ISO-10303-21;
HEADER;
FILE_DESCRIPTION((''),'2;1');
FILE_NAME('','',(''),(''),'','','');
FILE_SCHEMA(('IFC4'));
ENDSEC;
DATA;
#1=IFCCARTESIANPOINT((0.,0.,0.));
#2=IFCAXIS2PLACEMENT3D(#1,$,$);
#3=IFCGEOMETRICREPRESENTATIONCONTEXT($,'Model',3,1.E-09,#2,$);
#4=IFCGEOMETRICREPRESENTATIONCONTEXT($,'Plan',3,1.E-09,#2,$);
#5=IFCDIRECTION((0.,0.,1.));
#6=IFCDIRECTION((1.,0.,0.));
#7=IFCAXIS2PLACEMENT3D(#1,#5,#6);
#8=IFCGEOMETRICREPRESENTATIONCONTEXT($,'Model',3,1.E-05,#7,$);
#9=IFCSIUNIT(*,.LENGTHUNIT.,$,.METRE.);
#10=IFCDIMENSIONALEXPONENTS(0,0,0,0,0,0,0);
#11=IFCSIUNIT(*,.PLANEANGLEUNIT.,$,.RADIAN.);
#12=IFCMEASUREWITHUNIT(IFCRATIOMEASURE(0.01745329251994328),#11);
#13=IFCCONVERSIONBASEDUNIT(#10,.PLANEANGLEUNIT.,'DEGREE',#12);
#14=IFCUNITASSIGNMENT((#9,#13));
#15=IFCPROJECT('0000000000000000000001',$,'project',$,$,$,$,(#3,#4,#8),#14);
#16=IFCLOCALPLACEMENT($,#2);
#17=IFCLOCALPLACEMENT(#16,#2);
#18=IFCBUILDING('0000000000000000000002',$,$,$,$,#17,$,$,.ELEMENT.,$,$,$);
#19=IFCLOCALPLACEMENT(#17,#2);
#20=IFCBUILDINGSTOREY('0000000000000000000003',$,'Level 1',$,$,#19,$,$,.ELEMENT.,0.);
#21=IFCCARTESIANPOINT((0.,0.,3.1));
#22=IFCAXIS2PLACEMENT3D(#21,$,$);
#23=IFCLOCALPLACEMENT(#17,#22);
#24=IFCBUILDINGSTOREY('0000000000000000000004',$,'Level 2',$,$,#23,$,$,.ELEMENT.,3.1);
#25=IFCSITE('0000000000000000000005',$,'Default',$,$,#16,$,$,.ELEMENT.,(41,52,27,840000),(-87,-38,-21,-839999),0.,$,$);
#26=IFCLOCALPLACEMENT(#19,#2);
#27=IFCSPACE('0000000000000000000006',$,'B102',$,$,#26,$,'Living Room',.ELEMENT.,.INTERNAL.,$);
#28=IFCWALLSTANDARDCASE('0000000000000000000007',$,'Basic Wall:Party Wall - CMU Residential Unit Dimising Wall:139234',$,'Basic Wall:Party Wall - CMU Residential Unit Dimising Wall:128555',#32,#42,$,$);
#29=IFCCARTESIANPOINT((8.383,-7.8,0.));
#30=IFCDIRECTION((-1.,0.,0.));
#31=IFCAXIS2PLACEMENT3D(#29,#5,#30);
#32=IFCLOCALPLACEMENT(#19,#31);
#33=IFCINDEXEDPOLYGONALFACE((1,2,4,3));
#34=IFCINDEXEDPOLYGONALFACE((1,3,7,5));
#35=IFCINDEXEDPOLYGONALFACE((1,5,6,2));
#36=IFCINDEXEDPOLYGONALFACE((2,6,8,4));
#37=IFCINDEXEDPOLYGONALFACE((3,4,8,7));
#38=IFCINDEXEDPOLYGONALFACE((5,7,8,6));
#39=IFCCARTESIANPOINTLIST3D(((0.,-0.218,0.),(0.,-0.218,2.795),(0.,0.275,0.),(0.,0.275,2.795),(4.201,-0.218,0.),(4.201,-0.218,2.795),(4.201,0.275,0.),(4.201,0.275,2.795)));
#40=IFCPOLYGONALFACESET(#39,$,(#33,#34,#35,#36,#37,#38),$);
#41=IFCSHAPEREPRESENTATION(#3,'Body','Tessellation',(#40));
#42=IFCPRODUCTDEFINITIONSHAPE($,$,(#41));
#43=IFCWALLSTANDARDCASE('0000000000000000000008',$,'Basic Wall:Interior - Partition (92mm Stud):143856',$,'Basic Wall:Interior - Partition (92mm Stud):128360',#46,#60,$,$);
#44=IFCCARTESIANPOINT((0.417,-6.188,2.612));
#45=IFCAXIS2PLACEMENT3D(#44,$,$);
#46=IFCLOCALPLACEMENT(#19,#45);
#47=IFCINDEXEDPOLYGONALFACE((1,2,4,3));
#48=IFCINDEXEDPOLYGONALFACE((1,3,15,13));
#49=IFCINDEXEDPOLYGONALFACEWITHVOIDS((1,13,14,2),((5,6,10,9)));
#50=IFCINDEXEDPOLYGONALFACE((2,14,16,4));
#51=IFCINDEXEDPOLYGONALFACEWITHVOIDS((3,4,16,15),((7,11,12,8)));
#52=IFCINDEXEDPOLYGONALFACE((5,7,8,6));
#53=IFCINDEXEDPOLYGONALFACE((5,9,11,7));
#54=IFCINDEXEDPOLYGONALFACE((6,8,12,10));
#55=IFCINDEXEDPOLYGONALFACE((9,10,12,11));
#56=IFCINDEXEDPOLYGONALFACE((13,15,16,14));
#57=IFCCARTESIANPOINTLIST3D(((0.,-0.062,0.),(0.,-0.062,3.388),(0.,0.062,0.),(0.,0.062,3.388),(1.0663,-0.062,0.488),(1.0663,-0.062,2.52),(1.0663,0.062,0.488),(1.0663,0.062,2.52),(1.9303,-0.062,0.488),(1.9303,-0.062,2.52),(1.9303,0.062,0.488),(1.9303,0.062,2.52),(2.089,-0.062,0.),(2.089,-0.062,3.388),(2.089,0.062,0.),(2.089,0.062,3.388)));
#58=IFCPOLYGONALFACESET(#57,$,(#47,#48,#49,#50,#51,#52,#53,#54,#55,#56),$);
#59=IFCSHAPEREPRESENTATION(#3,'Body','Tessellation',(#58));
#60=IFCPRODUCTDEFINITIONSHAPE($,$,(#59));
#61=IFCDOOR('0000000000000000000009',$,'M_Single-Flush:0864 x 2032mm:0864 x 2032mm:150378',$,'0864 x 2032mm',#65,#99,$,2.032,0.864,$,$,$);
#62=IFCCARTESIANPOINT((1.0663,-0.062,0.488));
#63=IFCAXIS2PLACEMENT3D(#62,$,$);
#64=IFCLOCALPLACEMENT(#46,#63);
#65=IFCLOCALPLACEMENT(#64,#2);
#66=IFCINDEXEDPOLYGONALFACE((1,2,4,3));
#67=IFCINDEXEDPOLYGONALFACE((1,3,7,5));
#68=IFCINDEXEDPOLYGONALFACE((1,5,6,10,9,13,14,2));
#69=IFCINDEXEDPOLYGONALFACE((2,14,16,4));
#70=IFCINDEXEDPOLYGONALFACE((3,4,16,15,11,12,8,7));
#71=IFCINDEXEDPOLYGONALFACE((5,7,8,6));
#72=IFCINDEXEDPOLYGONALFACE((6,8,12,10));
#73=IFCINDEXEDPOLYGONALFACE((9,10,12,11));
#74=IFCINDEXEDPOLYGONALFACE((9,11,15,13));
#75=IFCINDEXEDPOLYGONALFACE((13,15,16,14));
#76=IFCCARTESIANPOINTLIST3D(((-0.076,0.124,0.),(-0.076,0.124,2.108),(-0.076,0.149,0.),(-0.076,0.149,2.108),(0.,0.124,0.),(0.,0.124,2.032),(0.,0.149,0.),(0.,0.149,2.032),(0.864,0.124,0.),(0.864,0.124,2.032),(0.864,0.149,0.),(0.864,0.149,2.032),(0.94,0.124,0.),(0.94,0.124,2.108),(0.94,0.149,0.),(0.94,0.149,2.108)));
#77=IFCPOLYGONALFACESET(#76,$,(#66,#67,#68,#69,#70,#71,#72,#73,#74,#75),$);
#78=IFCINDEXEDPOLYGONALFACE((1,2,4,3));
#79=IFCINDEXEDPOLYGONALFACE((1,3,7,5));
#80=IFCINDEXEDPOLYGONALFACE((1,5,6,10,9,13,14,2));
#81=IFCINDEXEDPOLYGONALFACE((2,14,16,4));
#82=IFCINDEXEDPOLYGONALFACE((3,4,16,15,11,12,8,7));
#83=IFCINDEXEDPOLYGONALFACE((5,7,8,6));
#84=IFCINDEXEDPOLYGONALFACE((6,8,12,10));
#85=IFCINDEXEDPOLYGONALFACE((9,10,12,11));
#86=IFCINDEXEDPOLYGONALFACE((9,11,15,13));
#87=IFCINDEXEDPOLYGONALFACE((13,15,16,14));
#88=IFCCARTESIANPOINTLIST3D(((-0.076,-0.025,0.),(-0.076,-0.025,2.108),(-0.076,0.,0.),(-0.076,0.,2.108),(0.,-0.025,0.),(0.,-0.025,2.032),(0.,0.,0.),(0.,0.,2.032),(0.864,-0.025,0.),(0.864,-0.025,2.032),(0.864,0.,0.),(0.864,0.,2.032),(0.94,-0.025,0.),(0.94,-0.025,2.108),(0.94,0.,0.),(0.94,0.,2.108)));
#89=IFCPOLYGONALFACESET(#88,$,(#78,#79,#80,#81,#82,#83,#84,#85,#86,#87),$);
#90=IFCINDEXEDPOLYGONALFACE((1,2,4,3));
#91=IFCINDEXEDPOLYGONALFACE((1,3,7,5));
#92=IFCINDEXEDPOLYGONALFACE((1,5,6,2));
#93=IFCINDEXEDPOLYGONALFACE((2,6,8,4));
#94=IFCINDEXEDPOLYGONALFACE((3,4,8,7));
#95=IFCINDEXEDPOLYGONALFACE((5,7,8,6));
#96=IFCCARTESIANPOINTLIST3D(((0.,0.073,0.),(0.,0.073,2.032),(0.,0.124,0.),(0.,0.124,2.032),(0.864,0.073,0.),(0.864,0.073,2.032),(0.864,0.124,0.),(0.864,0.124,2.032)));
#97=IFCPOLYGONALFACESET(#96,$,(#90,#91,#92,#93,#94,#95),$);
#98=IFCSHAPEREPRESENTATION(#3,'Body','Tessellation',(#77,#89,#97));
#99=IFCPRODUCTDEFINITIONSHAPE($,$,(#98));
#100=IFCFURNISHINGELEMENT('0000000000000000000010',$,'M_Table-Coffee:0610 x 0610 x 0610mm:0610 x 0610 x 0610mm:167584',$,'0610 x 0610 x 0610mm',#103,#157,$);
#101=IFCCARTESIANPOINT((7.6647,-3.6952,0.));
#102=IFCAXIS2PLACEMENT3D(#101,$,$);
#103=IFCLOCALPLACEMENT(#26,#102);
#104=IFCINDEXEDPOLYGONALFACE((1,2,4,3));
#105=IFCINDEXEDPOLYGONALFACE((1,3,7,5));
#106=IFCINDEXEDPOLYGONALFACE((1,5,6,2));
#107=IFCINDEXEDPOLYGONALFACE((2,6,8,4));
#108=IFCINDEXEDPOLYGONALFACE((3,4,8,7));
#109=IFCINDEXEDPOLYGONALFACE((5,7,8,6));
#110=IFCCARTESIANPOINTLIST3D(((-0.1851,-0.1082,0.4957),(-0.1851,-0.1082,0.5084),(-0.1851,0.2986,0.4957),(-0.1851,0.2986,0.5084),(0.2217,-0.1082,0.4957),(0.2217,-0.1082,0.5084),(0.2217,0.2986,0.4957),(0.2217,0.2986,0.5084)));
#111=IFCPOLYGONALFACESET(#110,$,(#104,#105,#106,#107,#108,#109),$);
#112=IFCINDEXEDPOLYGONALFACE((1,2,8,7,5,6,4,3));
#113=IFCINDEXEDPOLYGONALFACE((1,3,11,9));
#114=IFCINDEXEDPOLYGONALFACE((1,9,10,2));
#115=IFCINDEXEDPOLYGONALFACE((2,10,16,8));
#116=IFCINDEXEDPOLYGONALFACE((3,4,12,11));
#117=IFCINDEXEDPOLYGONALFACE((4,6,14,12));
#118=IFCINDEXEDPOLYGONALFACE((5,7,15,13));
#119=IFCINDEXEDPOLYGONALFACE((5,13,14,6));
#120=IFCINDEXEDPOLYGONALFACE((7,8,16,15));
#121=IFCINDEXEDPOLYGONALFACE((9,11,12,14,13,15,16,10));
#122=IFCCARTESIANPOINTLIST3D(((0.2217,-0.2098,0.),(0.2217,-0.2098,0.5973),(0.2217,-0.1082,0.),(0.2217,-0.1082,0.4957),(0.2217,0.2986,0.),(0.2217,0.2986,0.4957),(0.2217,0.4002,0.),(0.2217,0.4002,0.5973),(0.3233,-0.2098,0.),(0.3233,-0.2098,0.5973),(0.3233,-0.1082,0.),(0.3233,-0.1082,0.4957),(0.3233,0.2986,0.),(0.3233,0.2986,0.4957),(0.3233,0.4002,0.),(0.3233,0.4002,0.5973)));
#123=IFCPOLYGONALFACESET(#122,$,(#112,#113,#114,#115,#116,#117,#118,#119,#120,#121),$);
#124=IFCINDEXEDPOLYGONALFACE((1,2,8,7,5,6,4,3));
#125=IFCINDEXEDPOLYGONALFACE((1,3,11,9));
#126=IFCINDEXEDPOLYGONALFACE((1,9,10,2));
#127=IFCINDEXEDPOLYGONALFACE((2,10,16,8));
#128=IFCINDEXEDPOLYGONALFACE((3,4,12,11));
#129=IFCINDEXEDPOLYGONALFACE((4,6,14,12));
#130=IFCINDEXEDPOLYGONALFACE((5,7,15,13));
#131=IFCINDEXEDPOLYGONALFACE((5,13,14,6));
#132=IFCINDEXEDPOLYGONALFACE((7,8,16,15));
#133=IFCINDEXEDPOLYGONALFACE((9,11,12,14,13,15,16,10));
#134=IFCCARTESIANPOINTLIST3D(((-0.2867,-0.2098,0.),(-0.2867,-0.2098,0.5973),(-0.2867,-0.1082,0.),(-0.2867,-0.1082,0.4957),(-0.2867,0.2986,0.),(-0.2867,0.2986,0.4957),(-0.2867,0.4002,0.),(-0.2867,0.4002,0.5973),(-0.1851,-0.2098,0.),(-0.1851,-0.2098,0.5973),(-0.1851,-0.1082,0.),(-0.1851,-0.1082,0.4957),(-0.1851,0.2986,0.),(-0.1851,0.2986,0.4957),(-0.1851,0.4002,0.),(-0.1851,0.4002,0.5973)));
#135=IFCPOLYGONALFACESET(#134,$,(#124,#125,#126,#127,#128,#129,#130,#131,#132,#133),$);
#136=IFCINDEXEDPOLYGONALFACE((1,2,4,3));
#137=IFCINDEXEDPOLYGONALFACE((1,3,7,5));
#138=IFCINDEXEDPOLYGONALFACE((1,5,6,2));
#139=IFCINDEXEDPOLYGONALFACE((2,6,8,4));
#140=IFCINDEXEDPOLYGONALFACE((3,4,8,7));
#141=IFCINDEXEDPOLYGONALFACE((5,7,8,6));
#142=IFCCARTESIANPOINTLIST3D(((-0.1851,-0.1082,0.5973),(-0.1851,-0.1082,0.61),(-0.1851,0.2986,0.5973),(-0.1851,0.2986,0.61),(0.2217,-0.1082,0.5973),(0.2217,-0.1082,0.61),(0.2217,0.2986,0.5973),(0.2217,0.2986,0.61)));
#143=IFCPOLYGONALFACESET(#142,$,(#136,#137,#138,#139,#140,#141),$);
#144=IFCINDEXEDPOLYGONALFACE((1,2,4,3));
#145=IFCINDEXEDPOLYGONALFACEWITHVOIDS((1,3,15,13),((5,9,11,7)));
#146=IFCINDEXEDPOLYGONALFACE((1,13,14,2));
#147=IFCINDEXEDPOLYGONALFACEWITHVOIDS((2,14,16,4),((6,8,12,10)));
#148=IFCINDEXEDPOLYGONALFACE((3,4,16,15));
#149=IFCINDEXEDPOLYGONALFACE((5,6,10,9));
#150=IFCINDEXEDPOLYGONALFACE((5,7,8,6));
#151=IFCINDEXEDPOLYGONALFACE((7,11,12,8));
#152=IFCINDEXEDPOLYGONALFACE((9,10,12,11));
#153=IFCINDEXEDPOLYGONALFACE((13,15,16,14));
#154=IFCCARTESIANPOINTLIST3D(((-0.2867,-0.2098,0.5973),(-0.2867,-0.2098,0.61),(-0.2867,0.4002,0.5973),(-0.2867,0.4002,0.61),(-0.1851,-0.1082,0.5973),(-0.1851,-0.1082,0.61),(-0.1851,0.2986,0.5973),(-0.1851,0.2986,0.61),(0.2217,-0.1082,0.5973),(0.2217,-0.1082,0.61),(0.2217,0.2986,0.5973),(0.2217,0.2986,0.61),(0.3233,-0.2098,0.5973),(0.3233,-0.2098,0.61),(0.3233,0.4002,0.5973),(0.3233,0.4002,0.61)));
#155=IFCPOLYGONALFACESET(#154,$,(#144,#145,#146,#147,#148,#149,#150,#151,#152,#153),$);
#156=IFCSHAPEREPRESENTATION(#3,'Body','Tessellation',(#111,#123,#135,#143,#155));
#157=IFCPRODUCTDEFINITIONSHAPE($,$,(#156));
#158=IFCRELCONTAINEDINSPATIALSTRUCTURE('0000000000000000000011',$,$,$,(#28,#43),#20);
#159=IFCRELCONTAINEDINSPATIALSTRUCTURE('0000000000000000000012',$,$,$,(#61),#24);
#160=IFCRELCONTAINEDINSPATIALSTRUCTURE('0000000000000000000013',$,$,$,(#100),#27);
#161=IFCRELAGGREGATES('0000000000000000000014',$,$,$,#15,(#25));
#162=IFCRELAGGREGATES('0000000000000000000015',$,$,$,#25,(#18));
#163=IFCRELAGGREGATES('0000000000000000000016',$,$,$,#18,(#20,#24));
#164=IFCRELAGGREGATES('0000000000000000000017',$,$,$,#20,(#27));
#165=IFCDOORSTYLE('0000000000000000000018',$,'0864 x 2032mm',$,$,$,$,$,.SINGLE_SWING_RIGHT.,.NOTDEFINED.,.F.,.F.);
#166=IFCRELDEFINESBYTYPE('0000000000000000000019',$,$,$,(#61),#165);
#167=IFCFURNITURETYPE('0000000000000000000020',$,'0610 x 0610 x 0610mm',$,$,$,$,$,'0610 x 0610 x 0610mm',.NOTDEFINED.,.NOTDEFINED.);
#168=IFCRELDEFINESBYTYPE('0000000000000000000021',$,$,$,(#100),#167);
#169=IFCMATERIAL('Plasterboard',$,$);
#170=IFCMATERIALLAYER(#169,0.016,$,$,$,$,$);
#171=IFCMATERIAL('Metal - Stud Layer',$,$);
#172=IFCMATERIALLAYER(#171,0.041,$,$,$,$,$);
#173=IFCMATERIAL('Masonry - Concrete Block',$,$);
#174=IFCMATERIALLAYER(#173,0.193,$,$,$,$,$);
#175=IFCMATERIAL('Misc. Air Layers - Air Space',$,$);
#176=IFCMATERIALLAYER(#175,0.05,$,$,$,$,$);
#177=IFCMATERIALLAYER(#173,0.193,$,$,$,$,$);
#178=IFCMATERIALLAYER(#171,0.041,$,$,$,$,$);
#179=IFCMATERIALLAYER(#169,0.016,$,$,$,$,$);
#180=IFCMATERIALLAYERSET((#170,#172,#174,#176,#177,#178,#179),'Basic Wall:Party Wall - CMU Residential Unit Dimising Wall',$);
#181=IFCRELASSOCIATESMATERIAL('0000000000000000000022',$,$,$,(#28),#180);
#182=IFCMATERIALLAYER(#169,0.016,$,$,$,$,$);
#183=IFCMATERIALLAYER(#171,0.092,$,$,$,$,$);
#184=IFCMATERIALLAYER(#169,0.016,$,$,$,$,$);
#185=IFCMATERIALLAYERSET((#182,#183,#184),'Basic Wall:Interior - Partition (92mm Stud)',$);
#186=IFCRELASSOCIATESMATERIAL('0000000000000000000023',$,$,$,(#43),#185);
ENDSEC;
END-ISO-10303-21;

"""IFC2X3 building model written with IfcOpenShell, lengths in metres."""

from ifc_helpers import new_model, entity, si_unit, converted_unit, frame, frame_2d, origin, origin_with_axes, origin_2d_with_axis, place, context, project, spatial, polyline, rectangle, outline, extrude, clip, bounded_halfspace, source, transform, mapped, material, layer, layer_set, layer_usage, type_object, type_shapes, element, fill, save


model = new_model("IFC2X3")

# Units and contexts
model_context_1 = context("Model", 3, precision=1e-09, world=origin())
plan_context = context("Plan", 3, precision=1e-09, world=origin())
model_context_2 = context("Model", 3, precision=1e-05, world=origin_with_axes())
ifc_project = project(units=[si_unit("LENGTHUNIT", "METRE"), converted_unit("PLANEANGLEUNIT", "DEGREE", entity("IfcRatioMeasure", 0.01745329251994328), si_unit("PLANEANGLEUNIT", "RADIAN"), dimensions=[0, 0, 0, 0, 0, 0, 0])], contexts=[model_context_1, plan_context, model_context_2])

# Site, building, storey
site_placement = place(None, origin())
site = spatial("IfcSite", under=ifc_project, at=site_placement, Name="Default", CompositionType="ELEMENT", RefLatitude=(41, 52, 27, 840000), RefLongitude=(-87, -38, -21, -839999), RefElevation=0.0)
building_placement = place(site_placement, origin())
building = spatial("IfcBuilding", under=site, at=building_placement, CompositionType="ELEMENT")
storey_1_placement = place(building_placement, origin())
storey_1 = spatial("IfcBuildingStorey", under=building, at=storey_1_placement, Name="Level 1", CompositionType="ELEMENT", Elevation=0.0)

# Shared definitions
ifc_material_1 = material(Name="Misc. Air Layers - Air Space")
ifc_material_2 = material(Name="Masonry - Concrete Block")
ifc_material_3 = material(Name="Metal - Stud Layer")
ifc_material_4 = material(Name="Plasterboard")

# Shared definitions
ifc_layer_1 = layer(ifc_material_4, 0.016)
ifc_layer_2 = layer(ifc_material_3, 0.092)
ifc_layer_3 = layer(ifc_material_4, 0.016)
ifc_layer_set_1 = layer_set([ifc_layer_1, ifc_layer_2, ifc_layer_3], Name="Basic Wall:Interior - Partition (92mm Stud)")

# Wall
ifc_layer_4 = layer(ifc_material_4, 0.016)
ifc_layer_5 = layer(ifc_material_3, 0.041)
ifc_layer_6 = layer(ifc_material_2, 0.193)
ifc_layer_7 = layer(ifc_material_1, 0.05)
ifc_layer_8 = layer(ifc_material_2, 0.193)
ifc_layer_9 = layer(ifc_material_3, 0.041)
ifc_layer_10 = layer(ifc_material_4, 0.016)
ifc_layer_set_2 = layer_set([ifc_layer_4, ifc_layer_5, ifc_layer_6, ifc_layer_7, ifc_layer_8, ifc_layer_9, ifc_layer_10], Name="Basic Wall:Party Wall - CMU Residential Unit Dimising Wall")
ifc_layer_usage_1 = layer_usage(ifc_layer_set_2, "AXIS2", "NEGATIVE", 0.275)
wall_1_placement = place(storey_1_placement, frame((8.383, -7.8, 0.0), z_axis=(0.0, 0.0, 1.0), x_axis=(-1.0, 0.0, 0.0)))
element("IfcWallStandardCase", 1, at=wall_1_placement, inside=storey_1, material=ifc_layer_usage_1, Name="Basic Wall:Party Wall - CMU Residential Unit Dimising Wall:139234", ObjectType="Basic Wall:Party Wall - CMU Residential Unit Dimising Wall:128555", context=model_context_1, shape_type="Clipping", body=[
    clip(clip(extrude(rectangle(XDim=4.201, YDim=0.55, at=frame_2d((2.1005, 0.0), x_axis=(-1.0, 0.0))), origin(), (0.0, 0.0, 1.0), 2.795), bounded_halfspace(frame((0.0, -0.218, 2.795), z_axis=(0.0, 1.0, 0.0), x_axis=(-1.0, 0.0, 0.0)), True, frame((0.0, -0.218, 2.795), z_axis=(0.0, 1.0, 0.0), x_axis=(-1.0, 0.0, 0.0)), polyline([(0.0, 0.0), (-3.708, 0.0), (-4.201, 0.0), (-4.201, -2.795), (0.0, -2.795), (0.0, 0.0)]))), bounded_halfspace(frame((4.201, 0.275, 0.0), z_axis=(-1.0, 0.0, 0.0), x_axis=(0.0, -1.0, 0.0)), True, frame((4.201, 0.275, 0.0), z_axis=(-1.0, 0.0, 0.0), x_axis=(0.0, -1.0, 0.0)), polyline([(0.0, 0.0), (0.493, 0.0), (0.493, 2.795), (0.0, 2.795), (0.0, 0.0)]))),
])

# Wall, opening
ifc_layer_usage_2 = layer_usage(ifc_layer_set_1, "AXIS2", "NEGATIVE", 0.062)
wall_2_placement = place(storey_1_placement, frame((0.417, -6.188, 2.612)))
wall_2 = element("IfcWallStandardCase", 2, at=wall_2_placement, inside=storey_1, material=ifc_layer_usage_2, Name="Basic Wall:Interior - Partition (92mm Stud):143856", ObjectType="Basic Wall:Interior - Partition (92mm Stud):128360", context=model_context_1, shape_type="SweptSolid", body=[
    extrude(rectangle(XDim=2.089, YDim=0.124, at=frame_2d((1.0445, 0.0), x_axis=(-1.0, 0.0))), origin(), (0.0, 0.0, 1.0), 3.388),
])
opening_1_placement = place(wall_2_placement, frame((1.0663, -0.062, 0.488)))
opening_1 = element("IfcOpeningElement", 3, at=opening_1_placement, cuts=wall_2, ObjectType="Opening", context=model_context_1, shape_type="SweptSolid", body=[
    extrude(rectangle(XDim=0.864, YDim=2.032, at=frame_2d((1.016, 0.432), x_axis=(0.0, 1.0))), frame((0.0, 0.0, 0.0), z_axis=(0.0, 1.0, 0.0), x_axis=(0.0, 0.0, 1.0)), (0.0, 0.0, 1.0), 0.124),
])

# Shared definitions
storey_2_placement = place(building_placement, frame((0.0, 0.0, 3.1)))
storey_2 = spatial("IfcBuildingStorey", under=building, at=storey_2_placement, Name="Level 2", CompositionType="ELEMENT", Elevation=3.1)

# Door
door_style_1 = type_object("IfcDoorStyle", Name="0864 x 2032mm", ConstructionType="NOTDEFINED", OperationType="SINGLE_SWING_RIGHT", ParameterTakesPrecedence=False, Sizeable=False)
shared_shape_1 = source(origin(), model_context_1, "Body", "SweptSolid", [
    extrude(outline(polyline([(-0.508, -1.073), (0.508, -1.073), (0.508, 1.035), (0.432, 1.035), (0.432, -0.997), (-0.432, -0.997), (-0.432, 1.035), (-0.508, 1.035), (-0.508, -1.073)])), frame((0.432, 0.124, 1.035), z_axis=(0.0, 1.0, 0.0), x_axis=(1.0, 0.0, 0.0)), (0.0, 0.0, 1.0), 0.025),
    extrude(outline(polyline([(-1.073, -0.508), (1.035, -0.508), (1.035, -0.432), (-0.997, -0.432), (-0.997, 0.432), (1.035, 0.432), (1.035, 0.508), (-1.073, 0.508), (-1.073, -0.508)])), frame((0.432, -0.025, 1.035), z_axis=(0.0, 1.0, 0.0), x_axis=(0.0, 0.0, -1.0)), (0.0, 0.0, 1.0), 0.025),
    extrude(rectangle(XDim=0.051, YDim=0.864, at=origin_2d_with_axis()), frame((0.432, 0.0985, 0.0), z_axis=(0.0, 0.0, 1.0), x_axis=(0.0, 1.0, 0.0)), (0.0, 0.0, 1.0), 2.032),
])
type_shapes(door_style_1, [shared_shape_1])
door_1_placement = place(opening_1_placement, origin())
door_1 = element("IfcDoor", 4, at=door_1_placement, inside=storey_2, type_object=door_style_1, Name="M_Single-Flush:0864 x 2032mm:0864 x 2032mm:150378", ObjectType="0864 x 2032mm", OverallHeight=2.032, OverallWidth=0.864, context=model_context_1, shape_type="MappedRepresentation", body=[
    mapped(shared_shape_1, transform((0.0, 0.0, 0.0), scale=1.0)),
])
fill(opening_1, door_1)

# Shared definitions
space_1_placement = place(storey_1_placement, origin())
space_1 = spatial("IfcSpace", under=storey_1, at=space_1_placement, Name="B102", LongName="Living Room", CompositionType="ELEMENT", InteriorOrExteriorSpace="INTERNAL")

# Furnishing element
furniture_type_1 = type_object("IfcFurnitureType", Name="0610 x 0610 x 0610mm", ElementType="0610 x 0610 x 0610mm", AssemblyPlace="NOTDEFINED")
shared_shape_2 = source(origin(), model_context_1, "Body", "SweptSolid", [
    extrude(rectangle(XDim=0.4068, YDim=0.4068, at=origin_2d_with_axis()), frame((0.0183, 0.0952, 0.4957), z_axis=(0.0, 0.0, 1.0), x_axis=(-1.0, 0.0, 0.0)), (0.0, 0.0, 1.0), 0.0127),
    extrude(outline(polyline([(-0.2732, -0.305), (0.324, -0.305), (0.324, 0.305), (-0.2732, 0.305), (-0.2732, 0.2034), (0.2225, 0.2034), (0.2225, -0.2034), (-0.2732, -0.2034), (-0.2732, -0.305)])), frame((0.2217, 0.0952, 0.2732), z_axis=(1.0, 0.0, 0.0), x_axis=(0.0, 0.0, 1.0)), (0.0, 0.0, 1.0), 0.1016),
    extrude(outline(polyline([(-0.305, -0.3241), (0.305, -0.3241), (0.305, 0.2733), (0.2034, 0.2733), (0.2034, -0.2224), (-0.2034, -0.2224), (-0.2034, 0.2733), (-0.305, 0.2733), (-0.305, -0.3241)])), frame((-0.2867, 0.0952, 0.2733), z_axis=(1.0, 0.0, 0.0), x_axis=(0.0, -1.0, 0.0)), (0.0, 0.0, 1.0), 0.1016),
    extrude(rectangle(XDim=0.4068, YDim=0.4068, at=origin_2d_with_axis()), frame((0.0183, 0.0952, 0.5973), z_axis=(0.0, 0.0, 1.0), x_axis=(-1.0, 0.0, 0.0)), (0.0, 0.0, 1.0), 0.0127),
    extrude(outline(polyline([(-0.305, -0.305), (0.305, -0.305), (0.305, 0.305), (-0.305, 0.305), (-0.305, -0.305)]), holes=[polyline([(-0.2034, -0.2034), (-0.2034, 0.2034), (0.2034, 0.2034), (0.2034, -0.2034), (-0.2034, -0.2034)])]), frame((0.0183, 0.0952, 0.5973), z_axis=(0.0, 0.0, 1.0), x_axis=(-1.0, 0.0, 0.0)), (0.0, 0.0, 1.0), 0.0127),
])
type_shapes(furniture_type_1, [shared_shape_2])
for number, where, name in (
    (5, (7.6647, -3.6952, 0.0), "M_Table-Coffee:0610 x 0610 x 0610mm:0610 x 0610 x 0610mm:167584"),
):
    element("IfcFurnishingElement", number, at=place(space_1_placement, frame(where)), inside=space_1, type_object=furniture_type_1, Name=name, ObjectType="0610 x 0610 x 0610mm", context=model_context_1, shape_type="MappedRepresentation", body=[
        mapped(shared_shape_2, transform((0.0, 0.0, 0.0), scale=1.0)),
    ])

save(model, "model.ifc")
